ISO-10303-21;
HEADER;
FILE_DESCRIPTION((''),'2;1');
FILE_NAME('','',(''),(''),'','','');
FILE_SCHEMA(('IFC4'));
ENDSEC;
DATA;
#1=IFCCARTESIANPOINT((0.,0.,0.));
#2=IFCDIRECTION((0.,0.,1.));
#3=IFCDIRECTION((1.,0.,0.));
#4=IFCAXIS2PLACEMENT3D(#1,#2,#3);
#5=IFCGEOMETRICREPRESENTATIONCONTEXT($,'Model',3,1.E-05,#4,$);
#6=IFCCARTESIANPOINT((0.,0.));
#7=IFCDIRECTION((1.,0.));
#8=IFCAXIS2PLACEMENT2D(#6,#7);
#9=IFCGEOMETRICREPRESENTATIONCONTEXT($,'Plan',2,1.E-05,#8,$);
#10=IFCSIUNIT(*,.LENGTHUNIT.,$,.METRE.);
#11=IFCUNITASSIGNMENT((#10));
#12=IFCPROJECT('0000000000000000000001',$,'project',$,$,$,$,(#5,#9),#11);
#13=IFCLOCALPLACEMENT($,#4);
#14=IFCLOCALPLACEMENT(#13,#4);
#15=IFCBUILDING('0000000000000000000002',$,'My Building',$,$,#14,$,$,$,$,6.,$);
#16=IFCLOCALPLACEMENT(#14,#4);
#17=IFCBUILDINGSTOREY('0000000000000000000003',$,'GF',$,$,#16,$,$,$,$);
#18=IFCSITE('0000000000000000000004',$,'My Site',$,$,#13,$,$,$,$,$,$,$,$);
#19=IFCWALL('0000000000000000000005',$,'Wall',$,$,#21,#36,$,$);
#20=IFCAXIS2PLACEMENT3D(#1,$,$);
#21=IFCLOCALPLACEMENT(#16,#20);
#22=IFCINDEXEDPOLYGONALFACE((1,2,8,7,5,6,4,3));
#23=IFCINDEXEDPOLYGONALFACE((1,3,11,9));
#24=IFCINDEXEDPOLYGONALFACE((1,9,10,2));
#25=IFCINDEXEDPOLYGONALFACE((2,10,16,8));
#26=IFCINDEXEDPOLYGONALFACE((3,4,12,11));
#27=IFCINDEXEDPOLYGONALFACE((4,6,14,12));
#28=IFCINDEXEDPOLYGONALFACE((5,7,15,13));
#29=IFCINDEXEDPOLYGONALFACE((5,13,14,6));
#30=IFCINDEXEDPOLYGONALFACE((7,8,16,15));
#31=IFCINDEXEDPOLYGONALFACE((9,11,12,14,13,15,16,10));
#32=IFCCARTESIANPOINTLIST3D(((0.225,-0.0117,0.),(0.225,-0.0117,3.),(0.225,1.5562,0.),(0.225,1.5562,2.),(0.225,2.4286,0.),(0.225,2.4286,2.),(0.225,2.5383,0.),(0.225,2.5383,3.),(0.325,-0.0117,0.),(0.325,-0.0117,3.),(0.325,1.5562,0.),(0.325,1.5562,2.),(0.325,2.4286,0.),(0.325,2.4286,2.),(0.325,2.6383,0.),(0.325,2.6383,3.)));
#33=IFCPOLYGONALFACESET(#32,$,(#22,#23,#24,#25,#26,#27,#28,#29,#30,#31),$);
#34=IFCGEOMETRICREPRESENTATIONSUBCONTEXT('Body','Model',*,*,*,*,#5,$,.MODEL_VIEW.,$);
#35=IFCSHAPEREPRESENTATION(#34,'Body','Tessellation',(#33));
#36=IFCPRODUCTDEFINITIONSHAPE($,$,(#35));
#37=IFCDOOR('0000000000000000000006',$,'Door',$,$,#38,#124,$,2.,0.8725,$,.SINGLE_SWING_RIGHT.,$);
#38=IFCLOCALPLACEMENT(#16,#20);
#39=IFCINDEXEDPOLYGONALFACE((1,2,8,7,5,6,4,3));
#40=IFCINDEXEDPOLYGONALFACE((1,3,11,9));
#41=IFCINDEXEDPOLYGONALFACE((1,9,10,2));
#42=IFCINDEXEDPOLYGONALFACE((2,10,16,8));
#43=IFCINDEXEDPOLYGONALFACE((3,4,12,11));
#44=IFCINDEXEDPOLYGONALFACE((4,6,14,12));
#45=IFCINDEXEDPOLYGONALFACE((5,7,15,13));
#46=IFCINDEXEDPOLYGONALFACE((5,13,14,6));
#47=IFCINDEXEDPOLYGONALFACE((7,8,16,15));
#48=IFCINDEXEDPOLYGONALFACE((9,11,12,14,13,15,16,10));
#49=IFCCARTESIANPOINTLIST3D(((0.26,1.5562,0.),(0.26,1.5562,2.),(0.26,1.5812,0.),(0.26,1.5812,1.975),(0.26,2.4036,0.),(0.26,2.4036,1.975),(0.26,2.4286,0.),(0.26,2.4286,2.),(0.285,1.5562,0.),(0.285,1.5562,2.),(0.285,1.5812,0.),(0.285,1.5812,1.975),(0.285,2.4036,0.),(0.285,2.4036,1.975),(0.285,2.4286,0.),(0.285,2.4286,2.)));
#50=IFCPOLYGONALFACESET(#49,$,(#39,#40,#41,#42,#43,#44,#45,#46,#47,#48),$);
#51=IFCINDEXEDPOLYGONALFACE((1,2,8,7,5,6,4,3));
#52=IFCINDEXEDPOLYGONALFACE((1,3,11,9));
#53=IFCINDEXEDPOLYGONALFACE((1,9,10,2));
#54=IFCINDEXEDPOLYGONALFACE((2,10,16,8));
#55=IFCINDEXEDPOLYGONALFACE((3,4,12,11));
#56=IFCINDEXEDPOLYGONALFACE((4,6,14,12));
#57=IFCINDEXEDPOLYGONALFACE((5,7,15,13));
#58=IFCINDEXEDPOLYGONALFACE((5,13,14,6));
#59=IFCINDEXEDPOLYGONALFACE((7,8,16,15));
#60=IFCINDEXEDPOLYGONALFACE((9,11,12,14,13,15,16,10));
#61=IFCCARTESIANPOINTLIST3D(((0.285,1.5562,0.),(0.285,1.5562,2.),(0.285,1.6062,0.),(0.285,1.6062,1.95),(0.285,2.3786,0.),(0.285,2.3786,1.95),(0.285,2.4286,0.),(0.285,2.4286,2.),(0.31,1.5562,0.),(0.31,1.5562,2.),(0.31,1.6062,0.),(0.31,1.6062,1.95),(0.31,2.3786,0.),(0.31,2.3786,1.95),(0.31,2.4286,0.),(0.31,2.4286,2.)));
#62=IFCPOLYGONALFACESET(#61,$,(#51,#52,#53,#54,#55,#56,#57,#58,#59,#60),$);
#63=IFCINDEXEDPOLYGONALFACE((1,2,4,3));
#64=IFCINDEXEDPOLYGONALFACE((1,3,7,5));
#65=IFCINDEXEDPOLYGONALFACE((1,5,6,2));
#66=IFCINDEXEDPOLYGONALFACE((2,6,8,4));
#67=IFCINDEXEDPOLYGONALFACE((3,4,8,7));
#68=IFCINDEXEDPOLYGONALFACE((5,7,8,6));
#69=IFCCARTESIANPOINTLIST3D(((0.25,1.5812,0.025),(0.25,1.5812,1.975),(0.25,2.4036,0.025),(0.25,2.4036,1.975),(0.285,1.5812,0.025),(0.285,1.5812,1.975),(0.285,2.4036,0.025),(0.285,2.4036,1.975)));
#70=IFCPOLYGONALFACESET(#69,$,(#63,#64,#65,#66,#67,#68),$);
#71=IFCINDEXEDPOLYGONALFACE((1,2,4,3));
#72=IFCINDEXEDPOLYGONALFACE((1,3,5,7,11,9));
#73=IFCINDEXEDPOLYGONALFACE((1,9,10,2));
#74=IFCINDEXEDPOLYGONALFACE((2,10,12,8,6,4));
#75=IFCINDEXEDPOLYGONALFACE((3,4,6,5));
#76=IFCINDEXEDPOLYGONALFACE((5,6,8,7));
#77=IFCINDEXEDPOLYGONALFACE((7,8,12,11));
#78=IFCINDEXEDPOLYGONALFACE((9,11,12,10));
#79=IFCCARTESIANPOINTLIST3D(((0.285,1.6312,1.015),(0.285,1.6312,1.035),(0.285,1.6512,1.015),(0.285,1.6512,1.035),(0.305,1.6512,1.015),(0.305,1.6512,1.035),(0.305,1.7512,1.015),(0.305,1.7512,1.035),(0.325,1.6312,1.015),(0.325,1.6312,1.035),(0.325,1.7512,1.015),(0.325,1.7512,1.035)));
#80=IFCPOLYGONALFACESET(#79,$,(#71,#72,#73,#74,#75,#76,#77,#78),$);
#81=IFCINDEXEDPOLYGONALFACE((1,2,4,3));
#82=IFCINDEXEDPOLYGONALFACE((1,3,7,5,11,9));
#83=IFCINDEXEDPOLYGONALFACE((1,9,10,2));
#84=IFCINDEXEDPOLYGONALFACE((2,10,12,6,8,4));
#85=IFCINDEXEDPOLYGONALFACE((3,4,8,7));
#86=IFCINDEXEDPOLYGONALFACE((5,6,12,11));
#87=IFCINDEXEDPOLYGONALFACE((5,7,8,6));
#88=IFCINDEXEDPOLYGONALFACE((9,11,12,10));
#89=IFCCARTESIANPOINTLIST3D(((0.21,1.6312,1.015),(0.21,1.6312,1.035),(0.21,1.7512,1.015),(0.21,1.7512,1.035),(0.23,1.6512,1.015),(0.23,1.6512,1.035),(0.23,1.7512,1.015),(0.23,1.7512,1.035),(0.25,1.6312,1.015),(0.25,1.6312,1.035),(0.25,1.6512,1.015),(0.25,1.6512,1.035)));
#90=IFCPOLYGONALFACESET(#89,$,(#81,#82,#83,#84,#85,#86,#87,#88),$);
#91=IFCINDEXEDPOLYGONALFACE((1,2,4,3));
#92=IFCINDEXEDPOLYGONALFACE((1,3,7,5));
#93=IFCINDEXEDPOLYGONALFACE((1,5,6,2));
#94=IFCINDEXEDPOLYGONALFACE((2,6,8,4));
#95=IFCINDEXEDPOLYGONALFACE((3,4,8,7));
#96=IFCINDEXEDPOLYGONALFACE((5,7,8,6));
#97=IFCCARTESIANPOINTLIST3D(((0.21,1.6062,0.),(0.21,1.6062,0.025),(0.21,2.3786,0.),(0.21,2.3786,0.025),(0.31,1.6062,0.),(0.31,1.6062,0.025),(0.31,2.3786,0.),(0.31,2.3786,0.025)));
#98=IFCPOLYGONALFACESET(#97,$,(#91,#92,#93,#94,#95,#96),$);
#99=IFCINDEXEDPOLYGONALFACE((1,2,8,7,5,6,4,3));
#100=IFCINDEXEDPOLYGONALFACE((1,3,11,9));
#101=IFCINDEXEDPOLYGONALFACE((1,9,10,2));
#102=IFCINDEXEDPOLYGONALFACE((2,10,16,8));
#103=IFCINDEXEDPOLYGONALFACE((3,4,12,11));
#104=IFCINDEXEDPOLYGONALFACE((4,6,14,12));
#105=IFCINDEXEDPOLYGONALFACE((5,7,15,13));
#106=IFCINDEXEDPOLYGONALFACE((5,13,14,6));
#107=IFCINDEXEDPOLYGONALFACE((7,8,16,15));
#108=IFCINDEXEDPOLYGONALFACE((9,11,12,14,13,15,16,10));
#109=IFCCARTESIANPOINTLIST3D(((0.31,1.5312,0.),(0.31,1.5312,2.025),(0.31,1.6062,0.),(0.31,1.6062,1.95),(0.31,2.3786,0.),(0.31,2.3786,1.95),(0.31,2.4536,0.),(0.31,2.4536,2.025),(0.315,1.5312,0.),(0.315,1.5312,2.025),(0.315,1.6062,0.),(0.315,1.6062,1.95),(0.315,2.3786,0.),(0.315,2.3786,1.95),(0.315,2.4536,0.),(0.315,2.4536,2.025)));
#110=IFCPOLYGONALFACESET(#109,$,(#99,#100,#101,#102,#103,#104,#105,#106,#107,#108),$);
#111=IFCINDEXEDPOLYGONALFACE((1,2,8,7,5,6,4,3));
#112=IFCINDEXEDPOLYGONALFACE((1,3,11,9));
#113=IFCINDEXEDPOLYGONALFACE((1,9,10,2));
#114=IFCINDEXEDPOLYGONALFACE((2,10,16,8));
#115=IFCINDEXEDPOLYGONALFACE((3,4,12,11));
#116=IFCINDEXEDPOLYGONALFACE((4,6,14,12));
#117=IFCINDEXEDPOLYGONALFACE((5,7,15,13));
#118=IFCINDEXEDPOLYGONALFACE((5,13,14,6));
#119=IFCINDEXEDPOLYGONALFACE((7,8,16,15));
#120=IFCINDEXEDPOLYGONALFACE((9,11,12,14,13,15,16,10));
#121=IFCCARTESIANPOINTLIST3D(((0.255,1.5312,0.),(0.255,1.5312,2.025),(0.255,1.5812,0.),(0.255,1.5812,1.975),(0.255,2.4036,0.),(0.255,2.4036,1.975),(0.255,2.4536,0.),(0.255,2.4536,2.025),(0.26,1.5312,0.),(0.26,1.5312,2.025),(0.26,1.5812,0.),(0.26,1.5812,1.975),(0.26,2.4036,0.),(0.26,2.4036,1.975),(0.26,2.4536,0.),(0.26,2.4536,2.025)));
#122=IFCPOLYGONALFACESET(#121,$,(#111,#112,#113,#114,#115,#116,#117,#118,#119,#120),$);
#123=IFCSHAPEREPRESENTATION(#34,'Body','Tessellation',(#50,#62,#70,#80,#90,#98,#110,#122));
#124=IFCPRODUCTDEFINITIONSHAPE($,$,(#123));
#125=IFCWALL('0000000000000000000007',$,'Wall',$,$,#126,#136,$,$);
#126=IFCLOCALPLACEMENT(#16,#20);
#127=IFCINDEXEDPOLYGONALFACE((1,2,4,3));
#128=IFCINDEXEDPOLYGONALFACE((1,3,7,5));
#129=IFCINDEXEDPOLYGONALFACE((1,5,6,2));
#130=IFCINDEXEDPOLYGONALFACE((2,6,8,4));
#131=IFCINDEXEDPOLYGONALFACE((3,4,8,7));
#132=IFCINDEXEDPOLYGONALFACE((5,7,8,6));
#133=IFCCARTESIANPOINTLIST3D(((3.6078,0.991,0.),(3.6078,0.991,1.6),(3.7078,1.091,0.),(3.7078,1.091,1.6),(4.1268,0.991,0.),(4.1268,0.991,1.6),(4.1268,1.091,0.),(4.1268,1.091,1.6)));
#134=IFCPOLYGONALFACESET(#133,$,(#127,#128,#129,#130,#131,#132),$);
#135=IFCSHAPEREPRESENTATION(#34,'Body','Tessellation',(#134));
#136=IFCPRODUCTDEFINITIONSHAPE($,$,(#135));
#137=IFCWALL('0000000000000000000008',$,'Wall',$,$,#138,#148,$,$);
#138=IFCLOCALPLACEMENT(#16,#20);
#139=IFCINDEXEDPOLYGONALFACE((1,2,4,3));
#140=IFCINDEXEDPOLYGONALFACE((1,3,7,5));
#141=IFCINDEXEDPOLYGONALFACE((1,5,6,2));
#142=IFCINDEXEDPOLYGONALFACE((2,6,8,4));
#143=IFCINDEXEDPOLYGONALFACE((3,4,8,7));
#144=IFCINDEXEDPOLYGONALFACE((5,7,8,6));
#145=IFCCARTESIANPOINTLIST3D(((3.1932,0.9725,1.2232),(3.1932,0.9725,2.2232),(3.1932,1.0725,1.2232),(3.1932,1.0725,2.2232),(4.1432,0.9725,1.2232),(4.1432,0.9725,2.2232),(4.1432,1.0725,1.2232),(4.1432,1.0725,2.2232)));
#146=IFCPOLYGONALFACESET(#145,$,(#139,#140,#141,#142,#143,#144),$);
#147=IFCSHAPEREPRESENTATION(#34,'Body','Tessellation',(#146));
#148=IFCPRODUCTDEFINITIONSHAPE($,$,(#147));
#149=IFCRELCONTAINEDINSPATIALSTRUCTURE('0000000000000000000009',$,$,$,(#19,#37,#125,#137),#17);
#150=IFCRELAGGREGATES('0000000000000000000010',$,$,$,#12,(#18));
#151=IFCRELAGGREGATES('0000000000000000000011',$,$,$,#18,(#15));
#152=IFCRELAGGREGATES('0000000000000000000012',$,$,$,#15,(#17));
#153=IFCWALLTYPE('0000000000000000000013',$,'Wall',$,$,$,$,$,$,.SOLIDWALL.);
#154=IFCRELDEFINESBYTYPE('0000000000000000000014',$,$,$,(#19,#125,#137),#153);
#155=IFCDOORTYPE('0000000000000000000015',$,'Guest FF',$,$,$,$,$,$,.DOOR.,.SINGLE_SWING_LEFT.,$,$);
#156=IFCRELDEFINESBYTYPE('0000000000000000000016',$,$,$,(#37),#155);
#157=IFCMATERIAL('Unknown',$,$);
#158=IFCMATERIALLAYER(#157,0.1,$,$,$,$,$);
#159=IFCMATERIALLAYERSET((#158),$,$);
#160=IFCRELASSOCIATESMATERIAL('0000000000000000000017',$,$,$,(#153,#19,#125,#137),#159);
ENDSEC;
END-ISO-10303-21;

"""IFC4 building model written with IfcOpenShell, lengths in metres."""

from ifc_helpers import new_model, entity, si_unit, frame, origin_with_axes, origin_2d_with_axis, place, context, subcontext, project, spatial, line, indexed_curve, outline, extrude, shape, source, transform, mapped, material, layer, layer_set, layer_usage, type_object, type_shapes, element, fill, save


model = new_model("IFC4")

# Units and contexts
model_context = context("Model", 3, precision=1e-05, world=origin_with_axes())
plan_context = context("Plan", 2, precision=1e-05, world=origin_2d_with_axis())
body_context_1 = subcontext(model_context, "Body", "Model", "MODEL_VIEW")
body_context_2 = subcontext(plan_context, "Body", "Plan", "PLAN_VIEW")
ifc_project = project(units=[si_unit("LENGTHUNIT", "METRE")], contexts=[model_context, plan_context])

# Site, building, storey
site_placement = place(None, origin_with_axes())
site = spatial("IfcSite", under=ifc_project, at=site_placement, Name="My Site")
building_placement = place(site_placement, origin_with_axes())
building = spatial("IfcBuilding", under=site, at=building_placement, Name="My Building", ElevationOfTerrain=6.0)
storey_placement = place(building_placement, origin_with_axes())
storey = spatial("IfcBuildingStorey", under=building, at=storey_placement, Name="GF")

# Shared definitions
ifc_material_1 = material(Name="Unknown")
ifc_layer = layer(ifc_material_1, 0.1)
ifc_layer_set = layer_set([ifc_layer])
wall_type = type_object("IfcWallType", Name="Wall", PredefinedType="SOLIDWALL", material=ifc_layer_set)

# Wall, opening, door
ifc_layer_usage_1 = layer_usage(ifc_layer_set, "AXIS2", "POSITIVE", 0.0)
wall_1_placement = place(storey_placement, frame((0.325, -0.0117, 0.0), z_axis=(0.0, 0.0, 1.0), x_axis=(0.0, 1.0, 0.0)))
wall_1 = element("IfcWall", 1, at=wall_1_placement, inside=storey, type_object=wall_type, material=ifc_layer_usage_1, Name="Wall", context=body_context_1, shape_type="SweptSolid", body=[
    extrude(outline(indexed_curve([(0.0, 0.0), (0.0, 0.1), (2.55, 0.1), (2.65, 0.0)], segments=[line(1, 2, 3, 4, 1)])), origin_with_axes(), (0.0, 0.0, 1.0), 3.0),
])
shared_shape_1 = source(origin_with_axes(), body_context_1, "Body", "SweptSolid", [
    extrude(outline(indexed_curve([(0.0, 0.0), (0.8725, 0.0), (0.8725, 2.0), (0.0, 2.0)], segments=[line(1, 2, 3, 4, 1)])), frame((0.0, -0.6, 0.0), z_axis=(0.0, -1.0, 0.0), x_axis=(1.0, 0.0, 0.0)), (0.0, 0.0, -1.0), 1.2),
])
opening_1_placement = place(wall_1_placement, frame((1.5679, 0.015, 0.0), z_axis=(0.0, 0.0, 1.0), x_axis=(1.0, 0.0, 0.0)))
opening_1 = element("IfcOpeningElement", 2, at=opening_1_placement, cuts=wall_1, PredefinedType="OPENING", context=body_context_1, shape_type="MappedRepresentation", body=[
    mapped(shared_shape_1, transform((0.0, 0.0, 0.0), x_axis=(1.0, 0.0, 0.0), y_axis=(0.0, 1.0, 0.0), z_axis=(0.0, 0.0, 1.0), scale=1.0)),
])
door_type_1 = type_object("IfcDoorType", Name="Guest FF", OperationType="SINGLE_SWING_LEFT", PredefinedType="DOOR")
shared_shape_2 = source(origin_with_axes(), body_context_1, "Body", "SweptSolid", [
    extrude(outline(indexed_curve([(0.0, 0.0), (0.0, 2.0), (0.8725, 2.0), (0.8725, 0.0), (0.8475, 0.0), (0.8475, 1.975), (0.025, 1.975), (0.025, 0.0)], segments=[line(1, 2, 3, 4, 5, 6, 7, 8, 1)])), frame((0.0, 0.025, 0.0), z_axis=(0.0, -1.0, 0.0), x_axis=(1.0, 0.0, 0.0)), (0.0, 0.0, -1.0), 0.025),
    extrude(outline(indexed_curve([(0.0, 0.0), (0.0, 2.0), (0.8725, 2.0), (0.8725, 0.0), (0.8225, 0.0), (0.8225, 1.95), (0.05, 1.95), (0.05, 0.0)], segments=[line(1, 2, 3, 4, 5, 6, 7, 8, 1)])), frame((0.0, 0.0, 0.0), z_axis=(0.0, -1.0, 0.0), x_axis=(1.0, 0.0, 0.0)), (0.0, 0.0, -1.0), 0.025),
    extrude(outline(indexed_curve([(0.0, 0.0), (0.8225, 0.0), (0.8225, 0.035), (0.0, 0.035)], segments=[line(1, 2, 3, 4, 1)])), frame((0.025, 0.025, 0.025), z_axis=(0.0, 0.0, 1.0), x_axis=(1.0, 0.0, 0.0)), (0.0, 0.0, 1.0), 1.95),
    extrude(outline(indexed_curve([(0.0, 0.0), (0.0, -0.04), (0.12, -0.04), (0.12, -0.02), (0.02, -0.02), (0.02, 0.0)], segments=[line(1, 2, 3, 4, 5, 6, 1)])), frame((0.075, 0.025, 1.015), z_axis=(0.0, 0.0, 1.0), x_axis=(1.0, 0.0, 0.0)), (0.0, 0.0, 1.0), 0.02),
    extrude(outline(indexed_curve([(0.0, 0.0), (0.0, 0.04), (0.12, 0.04), (0.12, 0.02), (0.02, 0.02), (0.02, 0.0)], segments=[line(1, 2, 3, 4, 5, 6, 1)])), frame((0.075, 0.06, 1.015), z_axis=(0.0, 0.0, 1.0), x_axis=(1.0, 0.0, 0.0)), (0.0, 0.0, 1.0), 0.02),
    extrude(outline(indexed_curve([(0.0, 0.0), (0.7725, 0.0), (0.7725, 0.1), (0.0, 0.1)], segments=[line(1, 2, 3, 4, 1)])), frame((0.05, 0.0, 0.0), z_axis=(0.0, 0.0, 1.0), x_axis=(1.0, 0.0, 0.0)), (0.0, 0.0, 1.0), 0.025),
    extrude(outline(indexed_curve([(0.0, 0.0), (0.0, 2.025), (0.9225, 2.025), (0.9225, 0.0), (0.8475, 0.0), (0.8475, 1.95), (0.075, 1.95), (0.075, 0.0)], segments=[line(1, 2, 3, 4, 5, 6, 7, 8, 1)])), frame((-0.025, -0.005, 0.0), z_axis=(0.0, -1.0, 0.0), x_axis=(1.0, 0.0, 0.0)), (0.0, 0.0, -1.0), 0.005),
    extrude(outline(indexed_curve([(0.0, 0.0), (0.0, 2.025), (0.9225, 2.025), (0.9225, 0.0), (0.8725, 0.0), (0.8725, 1.975), (0.05, 1.975), (0.05, 0.0)], segments=[line(1, 2, 3, 4, 5, 6, 7, 8, 1)])), frame((-0.025, 0.05, 0.0), z_axis=(0.0, -1.0, 0.0), x_axis=(1.0, 0.0, 0.0)), (0.0, 0.0, -1.0), 0.005),
])
shared_shape_3 = source(origin_with_axes(), body_context_2, "Body", "Curve2D", [
    entity("IfcIndexedPolyCurve", entity("IfcCartesianPointList2D", [[0.0, 0.0], [0.0, 0.05], [0.025, 0.05], [0.025, 0.025], [0.05, 0.025], [0.05, 0.0]]), [entity("IfcLineIndex", [1, 2, 3, 4, 5, 6, 1])]),
    entity("IfcIndexedPolyCurve", entity("IfcCartesianPointList2D", [[0.8725, 0.0], [0.8725, 0.05], [0.8475, 0.05], [0.8475, 0.025], [0.8225, 0.025], [0.8225, 0.0]]), [entity("IfcLineIndex", [1, 2, 3, 4, 5, 6, 1])]),
    entity("IfcTrimmedCurve", entity("IfcEllipse", entity("IfcAxis2Placement2D", entity("IfcCartesianPoint", [0.8125, 0.05]), entity("IfcDirection", [1.0, 0.0])), 0.7875, 0.8225), [entity("IfcCartesianPoint", [0.8125, 0.8725])], [entity("IfcCartesianPoint", [0.025, 0.05])], True, "CARTESIAN"),
    entity("IfcIndexedPolyCurve", entity("IfcCartesianPointList2D", [[0.8475, 0.05], [0.8125, 0.05], [0.8125, 0.8725], [0.8475, 0.8725]]), [entity("IfcLineIndex", [1, 2, 3, 4, 1])]),
])
type_shapes(door_type_1, [shared_shape_2, shared_shape_3])
door_1_placement = place(opening_1_placement, frame((0.0, 0.0, 0.0), z_axis=(0.0, 0.0, 1.0), x_axis=(1.0, 0.0, 0.0)))
door_1 = element("IfcDoor", 3, at=door_1_placement, inside=storey, type_object=door_type_1, Name="Door", OperationType="SINGLE_SWING_RIGHT", OverallHeight=2.0, OverallWidth=0.8725, shapes=[
    shape(body_context_1, "Body", "MappedRepresentation", [mapped(shared_shape_2, transform((0.0, 0.0, 0.0), x_axis=(1.0, 0.0, 0.0), y_axis=(0.0, 1.0, 0.0), z_axis=(0.0, 0.0, 1.0), scale=1.0))]),
    shape(body_context_2, "Body", "MappedRepresentation", [mapped(shared_shape_3, transform((0.0, 0.0, 0.0), x_axis=(1.0, 0.0, 0.0), y_axis=(0.0, 1.0, 0.0), z_axis=(0.0, 0.0, 1.0), scale=1.0))]),
])
fill(opening_1, door_1)

# Walls
ifc_layer_usage_2 = layer_usage(ifc_layer_set, "AXIS2", "POSITIVE", 0.0)
wall_2_placement = place(storey_placement, frame((3.6078, 0.991, 0.0), z_axis=(0.0, 0.0, 1.0), x_axis=(1.0, 0.0, 0.0)))
element("IfcWall", 4, at=wall_2_placement, inside=storey, type_object=wall_type, material=ifc_layer_usage_2, Name="Wall", context=body_context_1, shape_type="SweptSolid", body=[
    extrude(outline(indexed_curve([(0.0, 0.0), (0.1, 0.1), (0.519, 0.1), (0.519, 0.0)], segments=[line(1, 2, 3, 4, 1)])), origin_with_axes(), (0.0, 0.0, 1.0), 1.6),
])
ifc_layer_usage_3 = layer_usage(ifc_layer_set, "AXIS2", "POSITIVE", 0.0)
wall_3_placement = place(storey_placement, frame((3.1932, 0.9725, 1.2232), z_axis=(0.0, 0.0, 1.0), x_axis=(1.0, 0.0, 0.0)))
element("IfcWall", 5, at=wall_3_placement, inside=storey, type_object=wall_type, material=ifc_layer_usage_3, Name="Wall", context=body_context_1, shape_type="SweptSolid", body=[
    extrude(outline(indexed_curve([(0.0, 0.0), (0.0, 0.1), (0.95, 0.1), (0.95, 0.0)], segments=[line(1, 2, 3, 4, 1)])), origin_with_axes(), (0.0, 0.0, 1.0), 1.0),
])

save(model, "model.ifc")
